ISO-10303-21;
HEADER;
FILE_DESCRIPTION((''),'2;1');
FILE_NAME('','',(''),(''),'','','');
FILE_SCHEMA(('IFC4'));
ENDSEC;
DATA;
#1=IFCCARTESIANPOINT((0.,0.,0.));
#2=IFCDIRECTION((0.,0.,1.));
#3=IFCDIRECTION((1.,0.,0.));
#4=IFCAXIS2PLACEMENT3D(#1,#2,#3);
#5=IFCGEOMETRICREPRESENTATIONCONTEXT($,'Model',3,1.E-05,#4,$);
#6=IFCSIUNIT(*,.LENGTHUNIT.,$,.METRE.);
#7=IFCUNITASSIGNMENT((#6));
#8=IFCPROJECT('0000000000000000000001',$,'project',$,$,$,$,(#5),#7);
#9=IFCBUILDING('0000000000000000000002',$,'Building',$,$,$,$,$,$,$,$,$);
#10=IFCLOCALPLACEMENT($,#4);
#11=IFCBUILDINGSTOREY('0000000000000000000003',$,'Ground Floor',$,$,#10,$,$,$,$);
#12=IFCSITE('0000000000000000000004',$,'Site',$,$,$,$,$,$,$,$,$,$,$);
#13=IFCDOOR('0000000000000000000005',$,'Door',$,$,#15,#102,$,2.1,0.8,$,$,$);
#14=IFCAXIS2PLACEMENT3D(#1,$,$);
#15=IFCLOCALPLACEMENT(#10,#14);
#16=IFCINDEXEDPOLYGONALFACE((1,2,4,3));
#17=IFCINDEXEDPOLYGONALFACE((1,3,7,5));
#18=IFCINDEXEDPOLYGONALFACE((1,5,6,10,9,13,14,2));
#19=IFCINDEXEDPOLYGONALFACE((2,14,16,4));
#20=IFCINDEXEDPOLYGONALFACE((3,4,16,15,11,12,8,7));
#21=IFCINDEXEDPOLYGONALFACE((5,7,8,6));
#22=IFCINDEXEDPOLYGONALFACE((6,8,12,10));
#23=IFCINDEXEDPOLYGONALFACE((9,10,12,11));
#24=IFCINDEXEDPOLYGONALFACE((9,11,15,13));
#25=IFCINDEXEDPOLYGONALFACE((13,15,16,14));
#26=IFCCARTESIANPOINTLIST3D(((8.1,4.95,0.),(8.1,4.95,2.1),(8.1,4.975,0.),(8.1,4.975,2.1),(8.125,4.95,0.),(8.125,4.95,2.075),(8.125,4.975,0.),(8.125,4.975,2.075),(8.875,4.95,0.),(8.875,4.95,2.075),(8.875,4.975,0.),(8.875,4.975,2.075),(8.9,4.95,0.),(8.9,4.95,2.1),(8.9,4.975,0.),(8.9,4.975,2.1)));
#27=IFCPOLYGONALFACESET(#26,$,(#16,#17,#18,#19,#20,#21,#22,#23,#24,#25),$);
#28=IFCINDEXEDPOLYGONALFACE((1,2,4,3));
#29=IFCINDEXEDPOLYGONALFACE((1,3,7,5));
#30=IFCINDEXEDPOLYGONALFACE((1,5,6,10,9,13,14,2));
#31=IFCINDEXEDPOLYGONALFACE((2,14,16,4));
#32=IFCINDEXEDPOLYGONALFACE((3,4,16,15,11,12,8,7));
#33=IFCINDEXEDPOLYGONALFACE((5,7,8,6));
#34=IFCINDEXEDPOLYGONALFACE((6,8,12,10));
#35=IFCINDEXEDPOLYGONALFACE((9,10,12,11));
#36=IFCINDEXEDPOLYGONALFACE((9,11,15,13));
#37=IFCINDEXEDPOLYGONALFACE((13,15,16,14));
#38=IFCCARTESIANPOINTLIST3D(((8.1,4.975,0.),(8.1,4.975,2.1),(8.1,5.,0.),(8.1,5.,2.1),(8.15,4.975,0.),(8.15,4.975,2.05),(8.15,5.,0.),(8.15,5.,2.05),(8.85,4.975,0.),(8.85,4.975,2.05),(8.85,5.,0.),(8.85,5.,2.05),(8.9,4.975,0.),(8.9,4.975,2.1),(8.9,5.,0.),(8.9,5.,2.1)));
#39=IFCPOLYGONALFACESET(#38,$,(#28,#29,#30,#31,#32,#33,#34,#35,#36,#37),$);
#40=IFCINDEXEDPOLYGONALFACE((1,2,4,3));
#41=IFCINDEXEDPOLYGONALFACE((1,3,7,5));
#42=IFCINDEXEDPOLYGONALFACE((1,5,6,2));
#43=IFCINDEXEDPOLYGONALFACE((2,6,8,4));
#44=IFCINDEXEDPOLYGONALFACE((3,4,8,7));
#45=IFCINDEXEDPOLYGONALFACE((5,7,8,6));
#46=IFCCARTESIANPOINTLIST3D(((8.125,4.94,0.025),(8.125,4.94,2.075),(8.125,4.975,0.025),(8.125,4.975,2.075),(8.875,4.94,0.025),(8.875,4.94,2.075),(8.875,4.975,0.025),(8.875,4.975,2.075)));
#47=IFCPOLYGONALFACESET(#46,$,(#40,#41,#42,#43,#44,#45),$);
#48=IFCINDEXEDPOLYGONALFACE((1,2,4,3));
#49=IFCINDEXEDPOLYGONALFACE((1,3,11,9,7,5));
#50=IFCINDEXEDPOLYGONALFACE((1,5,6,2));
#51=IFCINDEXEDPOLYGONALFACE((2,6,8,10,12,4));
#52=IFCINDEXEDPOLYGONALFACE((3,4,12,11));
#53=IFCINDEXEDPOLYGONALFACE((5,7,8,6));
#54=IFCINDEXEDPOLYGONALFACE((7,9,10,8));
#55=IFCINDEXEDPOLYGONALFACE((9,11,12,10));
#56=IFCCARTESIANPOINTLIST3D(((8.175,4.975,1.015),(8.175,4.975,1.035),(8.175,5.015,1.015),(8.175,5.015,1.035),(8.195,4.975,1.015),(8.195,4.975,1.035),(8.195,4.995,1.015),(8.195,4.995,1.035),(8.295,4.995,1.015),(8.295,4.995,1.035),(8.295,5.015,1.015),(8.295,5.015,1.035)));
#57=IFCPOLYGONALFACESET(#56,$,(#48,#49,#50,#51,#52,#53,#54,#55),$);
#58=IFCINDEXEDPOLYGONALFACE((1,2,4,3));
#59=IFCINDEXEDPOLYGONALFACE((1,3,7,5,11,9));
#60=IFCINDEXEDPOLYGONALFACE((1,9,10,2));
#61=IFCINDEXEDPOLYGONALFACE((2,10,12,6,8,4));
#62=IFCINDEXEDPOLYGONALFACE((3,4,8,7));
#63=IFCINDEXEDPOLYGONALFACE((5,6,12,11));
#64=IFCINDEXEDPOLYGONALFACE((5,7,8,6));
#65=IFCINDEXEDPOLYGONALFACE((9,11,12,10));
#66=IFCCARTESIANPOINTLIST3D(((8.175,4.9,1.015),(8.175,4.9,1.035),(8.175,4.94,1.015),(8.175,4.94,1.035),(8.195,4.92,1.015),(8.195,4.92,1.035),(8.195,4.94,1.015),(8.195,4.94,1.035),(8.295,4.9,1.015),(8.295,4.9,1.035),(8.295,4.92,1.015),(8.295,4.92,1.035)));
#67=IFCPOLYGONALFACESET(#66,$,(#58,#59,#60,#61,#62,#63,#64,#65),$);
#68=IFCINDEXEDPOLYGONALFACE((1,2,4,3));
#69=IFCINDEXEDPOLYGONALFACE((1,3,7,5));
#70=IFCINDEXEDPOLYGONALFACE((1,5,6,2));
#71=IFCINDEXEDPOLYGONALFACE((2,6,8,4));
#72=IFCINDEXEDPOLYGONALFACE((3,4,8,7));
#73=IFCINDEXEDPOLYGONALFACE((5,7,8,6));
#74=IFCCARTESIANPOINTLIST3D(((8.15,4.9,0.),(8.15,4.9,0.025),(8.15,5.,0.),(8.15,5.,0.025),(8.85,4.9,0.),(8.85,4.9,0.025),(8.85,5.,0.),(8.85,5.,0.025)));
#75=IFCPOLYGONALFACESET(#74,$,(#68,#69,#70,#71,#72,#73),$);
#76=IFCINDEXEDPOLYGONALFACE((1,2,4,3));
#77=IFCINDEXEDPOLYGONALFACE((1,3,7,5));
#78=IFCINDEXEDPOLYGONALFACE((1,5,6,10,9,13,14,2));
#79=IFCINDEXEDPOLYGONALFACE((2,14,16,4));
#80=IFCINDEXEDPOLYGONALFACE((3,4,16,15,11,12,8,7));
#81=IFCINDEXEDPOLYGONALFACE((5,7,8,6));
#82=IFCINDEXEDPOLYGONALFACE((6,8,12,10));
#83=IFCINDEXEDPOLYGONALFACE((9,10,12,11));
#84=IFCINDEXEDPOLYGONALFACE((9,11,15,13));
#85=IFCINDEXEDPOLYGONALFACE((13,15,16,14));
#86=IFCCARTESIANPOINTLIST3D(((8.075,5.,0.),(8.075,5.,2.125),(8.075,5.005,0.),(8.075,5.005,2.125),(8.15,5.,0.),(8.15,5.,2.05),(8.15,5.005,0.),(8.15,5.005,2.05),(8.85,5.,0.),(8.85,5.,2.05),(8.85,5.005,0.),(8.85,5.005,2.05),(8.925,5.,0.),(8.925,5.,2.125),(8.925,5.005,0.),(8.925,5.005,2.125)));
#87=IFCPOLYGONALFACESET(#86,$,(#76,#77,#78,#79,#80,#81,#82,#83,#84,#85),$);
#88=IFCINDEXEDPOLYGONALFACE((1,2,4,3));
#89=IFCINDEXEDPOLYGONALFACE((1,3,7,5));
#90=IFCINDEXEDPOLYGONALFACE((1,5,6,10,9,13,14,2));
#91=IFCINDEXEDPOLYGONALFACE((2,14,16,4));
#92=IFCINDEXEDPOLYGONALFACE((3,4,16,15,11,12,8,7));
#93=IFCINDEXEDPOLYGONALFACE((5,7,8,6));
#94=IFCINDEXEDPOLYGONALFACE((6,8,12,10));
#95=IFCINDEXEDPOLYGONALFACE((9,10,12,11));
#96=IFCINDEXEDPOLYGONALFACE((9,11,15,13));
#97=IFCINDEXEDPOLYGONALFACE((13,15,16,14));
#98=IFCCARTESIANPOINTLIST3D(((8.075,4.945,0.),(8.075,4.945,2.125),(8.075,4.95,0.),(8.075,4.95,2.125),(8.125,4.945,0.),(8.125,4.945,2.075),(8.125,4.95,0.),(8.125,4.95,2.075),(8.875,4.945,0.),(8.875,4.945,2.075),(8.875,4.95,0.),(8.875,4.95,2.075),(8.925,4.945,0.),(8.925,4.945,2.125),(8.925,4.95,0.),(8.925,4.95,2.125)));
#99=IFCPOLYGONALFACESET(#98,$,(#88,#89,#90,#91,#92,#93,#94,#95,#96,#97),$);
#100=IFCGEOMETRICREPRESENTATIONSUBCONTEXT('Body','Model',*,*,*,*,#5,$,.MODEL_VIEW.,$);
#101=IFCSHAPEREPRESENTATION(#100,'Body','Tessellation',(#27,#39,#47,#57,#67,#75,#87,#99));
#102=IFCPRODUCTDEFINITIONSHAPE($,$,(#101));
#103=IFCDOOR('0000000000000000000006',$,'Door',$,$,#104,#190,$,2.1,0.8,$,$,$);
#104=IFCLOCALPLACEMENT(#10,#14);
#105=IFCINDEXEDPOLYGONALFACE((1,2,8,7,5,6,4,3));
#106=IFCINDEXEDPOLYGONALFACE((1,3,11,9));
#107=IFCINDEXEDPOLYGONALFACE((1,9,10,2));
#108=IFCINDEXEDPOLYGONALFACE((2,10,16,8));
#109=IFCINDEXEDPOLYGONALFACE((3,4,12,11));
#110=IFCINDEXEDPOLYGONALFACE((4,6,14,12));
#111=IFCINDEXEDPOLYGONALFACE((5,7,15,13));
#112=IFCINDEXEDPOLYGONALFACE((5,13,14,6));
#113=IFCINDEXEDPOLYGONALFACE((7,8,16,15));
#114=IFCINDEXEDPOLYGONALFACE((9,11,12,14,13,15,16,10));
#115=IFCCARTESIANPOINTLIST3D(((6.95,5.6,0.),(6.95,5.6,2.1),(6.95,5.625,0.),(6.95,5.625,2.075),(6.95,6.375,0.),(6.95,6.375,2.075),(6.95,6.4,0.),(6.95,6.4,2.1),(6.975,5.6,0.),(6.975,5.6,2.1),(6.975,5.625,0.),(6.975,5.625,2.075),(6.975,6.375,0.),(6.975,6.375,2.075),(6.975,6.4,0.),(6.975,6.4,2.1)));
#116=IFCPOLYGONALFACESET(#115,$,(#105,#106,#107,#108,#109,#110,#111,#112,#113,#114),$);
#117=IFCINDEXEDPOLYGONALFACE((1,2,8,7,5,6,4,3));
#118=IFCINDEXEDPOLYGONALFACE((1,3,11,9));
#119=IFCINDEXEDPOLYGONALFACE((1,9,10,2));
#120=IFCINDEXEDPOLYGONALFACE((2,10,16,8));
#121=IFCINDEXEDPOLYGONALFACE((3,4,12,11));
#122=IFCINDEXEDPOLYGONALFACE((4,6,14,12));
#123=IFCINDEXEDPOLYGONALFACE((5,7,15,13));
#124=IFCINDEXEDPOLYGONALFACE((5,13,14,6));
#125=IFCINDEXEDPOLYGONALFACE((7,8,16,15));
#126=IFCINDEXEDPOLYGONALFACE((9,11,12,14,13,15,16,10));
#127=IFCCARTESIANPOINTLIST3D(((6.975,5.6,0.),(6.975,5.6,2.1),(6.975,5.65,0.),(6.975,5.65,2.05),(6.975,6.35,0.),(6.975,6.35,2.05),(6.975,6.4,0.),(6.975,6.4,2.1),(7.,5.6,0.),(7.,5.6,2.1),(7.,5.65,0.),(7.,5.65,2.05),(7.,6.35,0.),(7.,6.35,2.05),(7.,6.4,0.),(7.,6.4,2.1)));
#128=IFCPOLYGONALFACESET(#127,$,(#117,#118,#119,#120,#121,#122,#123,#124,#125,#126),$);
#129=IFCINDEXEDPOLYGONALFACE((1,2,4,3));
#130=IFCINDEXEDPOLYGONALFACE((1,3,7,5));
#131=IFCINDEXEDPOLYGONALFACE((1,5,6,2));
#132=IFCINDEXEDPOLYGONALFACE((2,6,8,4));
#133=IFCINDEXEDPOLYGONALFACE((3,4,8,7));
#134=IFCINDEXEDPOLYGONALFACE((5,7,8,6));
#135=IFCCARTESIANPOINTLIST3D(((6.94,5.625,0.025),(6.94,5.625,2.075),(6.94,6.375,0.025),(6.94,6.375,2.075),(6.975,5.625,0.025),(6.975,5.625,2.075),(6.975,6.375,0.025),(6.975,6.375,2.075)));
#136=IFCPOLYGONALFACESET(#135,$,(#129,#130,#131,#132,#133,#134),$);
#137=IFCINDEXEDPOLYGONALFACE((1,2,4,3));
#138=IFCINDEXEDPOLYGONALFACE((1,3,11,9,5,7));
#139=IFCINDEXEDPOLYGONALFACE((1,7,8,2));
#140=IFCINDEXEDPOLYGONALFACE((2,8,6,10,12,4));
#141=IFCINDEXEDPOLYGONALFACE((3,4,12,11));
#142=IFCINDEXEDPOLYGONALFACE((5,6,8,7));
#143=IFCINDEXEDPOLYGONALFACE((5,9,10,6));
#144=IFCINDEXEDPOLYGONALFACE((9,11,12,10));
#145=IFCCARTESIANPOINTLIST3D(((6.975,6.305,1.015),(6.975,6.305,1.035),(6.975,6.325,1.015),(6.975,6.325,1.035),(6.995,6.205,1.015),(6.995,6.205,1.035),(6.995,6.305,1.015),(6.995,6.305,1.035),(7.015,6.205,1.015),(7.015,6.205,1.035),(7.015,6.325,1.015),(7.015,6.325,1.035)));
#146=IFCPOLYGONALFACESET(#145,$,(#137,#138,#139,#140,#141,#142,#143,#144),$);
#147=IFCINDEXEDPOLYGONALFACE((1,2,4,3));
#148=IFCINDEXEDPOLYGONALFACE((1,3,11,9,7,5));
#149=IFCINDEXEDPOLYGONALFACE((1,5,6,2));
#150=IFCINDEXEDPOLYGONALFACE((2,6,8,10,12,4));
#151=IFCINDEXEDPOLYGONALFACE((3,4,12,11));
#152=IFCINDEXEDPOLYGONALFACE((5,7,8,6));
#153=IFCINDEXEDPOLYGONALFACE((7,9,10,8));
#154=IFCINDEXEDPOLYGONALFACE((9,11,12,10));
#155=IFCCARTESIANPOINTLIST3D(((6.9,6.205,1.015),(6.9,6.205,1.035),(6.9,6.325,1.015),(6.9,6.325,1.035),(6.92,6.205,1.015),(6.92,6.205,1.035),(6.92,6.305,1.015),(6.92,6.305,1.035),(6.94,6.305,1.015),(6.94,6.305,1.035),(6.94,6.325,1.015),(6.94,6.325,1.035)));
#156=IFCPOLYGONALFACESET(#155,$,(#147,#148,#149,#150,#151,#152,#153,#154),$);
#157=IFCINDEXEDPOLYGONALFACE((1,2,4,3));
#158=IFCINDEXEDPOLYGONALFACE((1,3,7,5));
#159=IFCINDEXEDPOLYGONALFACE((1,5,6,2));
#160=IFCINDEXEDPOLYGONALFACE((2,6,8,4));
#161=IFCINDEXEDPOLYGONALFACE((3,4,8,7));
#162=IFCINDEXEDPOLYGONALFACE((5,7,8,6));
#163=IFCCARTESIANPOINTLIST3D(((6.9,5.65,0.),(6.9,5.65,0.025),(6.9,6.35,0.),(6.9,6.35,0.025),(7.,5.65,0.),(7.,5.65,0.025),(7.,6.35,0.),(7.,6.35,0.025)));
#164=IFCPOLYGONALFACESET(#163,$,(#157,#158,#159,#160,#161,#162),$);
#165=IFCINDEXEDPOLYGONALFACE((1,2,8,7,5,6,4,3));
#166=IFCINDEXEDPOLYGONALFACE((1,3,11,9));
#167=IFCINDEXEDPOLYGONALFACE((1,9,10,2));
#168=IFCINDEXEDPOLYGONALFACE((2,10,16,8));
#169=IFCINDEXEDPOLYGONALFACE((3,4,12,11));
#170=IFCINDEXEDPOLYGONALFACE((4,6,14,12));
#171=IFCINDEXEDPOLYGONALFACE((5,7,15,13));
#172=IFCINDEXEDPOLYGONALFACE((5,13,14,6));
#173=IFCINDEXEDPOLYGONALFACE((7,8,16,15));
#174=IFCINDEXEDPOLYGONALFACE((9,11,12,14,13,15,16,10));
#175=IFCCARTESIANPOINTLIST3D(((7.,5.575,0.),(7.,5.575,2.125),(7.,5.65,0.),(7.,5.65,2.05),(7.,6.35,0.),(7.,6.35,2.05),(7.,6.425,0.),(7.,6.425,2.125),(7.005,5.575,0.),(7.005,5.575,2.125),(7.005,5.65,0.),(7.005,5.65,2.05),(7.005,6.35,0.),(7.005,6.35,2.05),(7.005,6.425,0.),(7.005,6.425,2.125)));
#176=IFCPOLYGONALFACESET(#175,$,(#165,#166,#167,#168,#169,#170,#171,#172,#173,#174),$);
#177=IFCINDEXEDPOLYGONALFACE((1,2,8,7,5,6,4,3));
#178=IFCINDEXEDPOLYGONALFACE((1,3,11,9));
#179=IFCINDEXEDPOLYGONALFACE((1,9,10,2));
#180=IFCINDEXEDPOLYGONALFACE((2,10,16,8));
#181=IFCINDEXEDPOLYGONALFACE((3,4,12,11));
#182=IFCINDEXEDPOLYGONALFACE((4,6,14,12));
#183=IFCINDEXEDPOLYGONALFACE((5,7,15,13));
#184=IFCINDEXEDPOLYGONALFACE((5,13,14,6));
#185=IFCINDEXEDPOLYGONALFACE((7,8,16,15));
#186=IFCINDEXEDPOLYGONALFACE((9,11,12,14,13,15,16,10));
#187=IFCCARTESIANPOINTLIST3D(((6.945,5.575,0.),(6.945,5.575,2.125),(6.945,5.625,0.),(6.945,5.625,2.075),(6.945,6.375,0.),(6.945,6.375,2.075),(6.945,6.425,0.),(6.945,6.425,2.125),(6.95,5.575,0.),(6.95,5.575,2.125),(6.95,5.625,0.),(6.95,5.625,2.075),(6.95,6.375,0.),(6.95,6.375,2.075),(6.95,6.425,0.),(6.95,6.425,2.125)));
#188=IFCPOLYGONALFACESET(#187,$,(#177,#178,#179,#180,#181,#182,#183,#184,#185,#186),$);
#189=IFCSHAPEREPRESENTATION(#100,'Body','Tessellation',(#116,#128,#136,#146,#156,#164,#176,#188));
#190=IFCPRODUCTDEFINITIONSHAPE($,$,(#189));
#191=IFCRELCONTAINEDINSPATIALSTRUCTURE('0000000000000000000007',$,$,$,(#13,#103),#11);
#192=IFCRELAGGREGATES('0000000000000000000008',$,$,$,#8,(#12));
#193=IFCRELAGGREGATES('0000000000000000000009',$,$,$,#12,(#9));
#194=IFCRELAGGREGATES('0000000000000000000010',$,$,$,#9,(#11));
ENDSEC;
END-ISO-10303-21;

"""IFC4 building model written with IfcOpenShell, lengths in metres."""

from ifc_helpers import new_model, si_unit, frame, origin_with_axes, place, context, subcontext, project, spatial, line, indexed_curve, outline, extrude, element, save


model = new_model("IFC4")

# Units and contexts
model_context = context("Model", 3, precision=1e-05, world=origin_with_axes())
body_context = subcontext(model_context, "Body", "Model", "MODEL_VIEW")
ifc_project = project(units=[si_unit("LENGTHUNIT", "METRE")], contexts=[model_context])

# Site, building, storey
site = spatial("IfcSite", under=ifc_project, Name="Site")
building = spatial("IfcBuilding", under=site, Name="Building")
storey_placement = place(None, origin_with_axes())
storey = spatial("IfcBuildingStorey", under=building, at=storey_placement, Name="Ground Floor")

# Doors
door_1_placement = place(storey_placement, frame((8.9, 5.0, 0.0), z_axis=(0.0, 0.0, 1.0), x_axis=(-1.0, 0.0, 0.0)))
element("IfcDoor", 1, at=door_1_placement, inside=storey, Name="Door", OverallHeight=2.1, OverallWidth=0.8, context=body_context, shape_type="SweptSolid", body=[
    extrude(outline(indexed_curve([(0.0, 0.0), (0.0, 2.1), (0.8, 2.1), (0.8, 0.0), (0.775, 0.0), (0.775, 2.075), (0.025, 2.075), (0.025, 0.0)], segments=[line(1, 2, 3, 4, 5, 6, 7, 8, 1)])), frame((0.0, 0.025, 0.0), z_axis=(0.0, -1.0, 0.0), x_axis=(1.0, 0.0, 0.0)), (0.0, 0.0, -1.0), 0.025),
    extrude(outline(indexed_curve([(0.0, 0.0), (0.0, 2.1), (0.8, 2.1), (0.8, 0.0), (0.75, 0.0), (0.75, 2.05), (0.05, 2.05), (0.05, 0.0)], segments=[line(1, 2, 3, 4, 5, 6, 7, 8, 1)])), frame((0.0, 0.0, 0.0), z_axis=(0.0, -1.0, 0.0), x_axis=(1.0, 0.0, 0.0)), (0.0, 0.0, -1.0), 0.025),
    extrude(outline(indexed_curve([(0.0, 0.0), (0.75, 0.0), (0.75, 0.035), (0.0, 0.035)], segments=[line(1, 2, 3, 4, 1)])), frame((0.025, 0.025, 0.025), z_axis=(0.0, 0.0, 1.0), x_axis=(1.0, 0.0, 0.0)), (0.0, 0.0, 1.0), 2.05),
    extrude(outline(indexed_curve([(0.0, 0.0), (0.0, -0.04), (-0.12, -0.04), (-0.12, -0.02), (-0.02, -0.02), (-0.02, 0.0)], segments=[line(1, 2, 3, 4, 5, 6, 1)])), frame((0.725, 0.025, 1.015), z_axis=(0.0, 0.0, 1.0), x_axis=(1.0, 0.0, 0.0)), (0.0, 0.0, 1.0), 0.02),
    extrude(outline(indexed_curve([(0.0, 0.0), (0.0, 0.04), (-0.12, 0.04), (-0.12, 0.02), (-0.02, 0.02), (-0.02, 0.0)], segments=[line(1, 2, 3, 4, 5, 6, 1)])), frame((0.725, 0.06, 1.015), z_axis=(0.0, 0.0, 1.0), x_axis=(1.0, 0.0, 0.0)), (0.0, 0.0, 1.0), 0.02),
    extrude(outline(indexed_curve([(0.0, 0.0), (0.7, 0.0), (0.7, 0.1), (0.0, 0.1)], segments=[line(1, 2, 3, 4, 1)])), frame((0.05, 0.0, 0.0), z_axis=(0.0, 0.0, 1.0), x_axis=(1.0, 0.0, 0.0)), (0.0, 0.0, 1.0), 0.025),
    extrude(outline(indexed_curve([(0.0, 0.0), (0.0, 2.125), (0.85, 2.125), (0.85, 0.0), (0.775, 0.0), (0.775, 2.05), (0.075, 2.05), (0.075, 0.0)], segments=[line(1, 2, 3, 4, 5, 6, 7, 8, 1)])), frame((-0.025, -0.005, 0.0), z_axis=(0.0, -1.0, 0.0), x_axis=(1.0, 0.0, 0.0)), (0.0, 0.0, -1.0), 0.005),
    extrude(outline(indexed_curve([(0.0, 0.0), (0.0, 2.125), (0.85, 2.125), (0.85, 0.0), (0.8, 0.0), (0.8, 2.075), (0.05, 2.075), (0.05, 0.0)], segments=[line(1, 2, 3, 4, 5, 6, 7, 8, 1)])), frame((-0.025, 0.05, 0.0), z_axis=(0.0, -1.0, 0.0), x_axis=(1.0, 0.0, 0.0)), (0.0, 0.0, -1.0), 0.005),
])
door_2_placement = place(storey_placement, frame((7.0, 5.6, 0.0), z_axis=(0.0, 0.0, 1.0), x_axis=(0.0, 1.0, 0.0)))
element("IfcDoor", 2, at=door_2_placement, inside=storey, Name="Door", OverallHeight=2.1, OverallWidth=0.8, context=body_context, shape_type="SweptSolid", body=[
    extrude(outline(indexed_curve([(0.0, 0.0), (0.0, 2.1), (0.8, 2.1), (0.8, 0.0), (0.775, 0.0), (0.775, 2.075), (0.025, 2.075), (0.025, 0.0)], segments=[line(1, 2, 3, 4, 5, 6, 7, 8, 1)])), frame((0.0, 0.025, 0.0), z_axis=(0.0, -1.0, 0.0), x_axis=(1.0, 0.0, 0.0)), (0.0, 0.0, -1.0), 0.025),
    extrude(outline(indexed_curve([(0.0, 0.0), (0.0, 2.1), (0.8, 2.1), (0.8, 0.0), (0.75, 0.0), (0.75, 2.05), (0.05, 2.05), (0.05, 0.0)], segments=[line(1, 2, 3, 4, 5, 6, 7, 8, 1)])), frame((0.0, 0.0, 0.0), z_axis=(0.0, -1.0, 0.0), x_axis=(1.0, 0.0, 0.0)), (0.0, 0.0, -1.0), 0.025),
    extrude(outline(indexed_curve([(0.0, 0.0), (0.75, 0.0), (0.75, 0.035), (0.0, 0.035)], segments=[line(1, 2, 3, 4, 1)])), frame((0.025, 0.025, 0.025), z_axis=(0.0, 0.0, 1.0), x_axis=(1.0, 0.0, 0.0)), (0.0, 0.0, 1.0), 2.05),
    extrude(outline(indexed_curve([(0.0, 0.0), (0.0, -0.04), (-0.12, -0.04), (-0.12, -0.02), (-0.02, -0.02), (-0.02, 0.0)], segments=[line(1, 2, 3, 4, 5, 6, 1)])), frame((0.725, 0.025, 1.015), z_axis=(0.0, 0.0, 1.0), x_axis=(1.0, 0.0, 0.0)), (0.0, 0.0, 1.0), 0.02),
    extrude(outline(indexed_curve([(0.0, 0.0), (0.0, 0.04), (-0.12, 0.04), (-0.12, 0.02), (-0.02, 0.02), (-0.02, 0.0)], segments=[line(1, 2, 3, 4, 5, 6, 1)])), frame((0.725, 0.06, 1.015), z_axis=(0.0, 0.0, 1.0), x_axis=(1.0, 0.0, 0.0)), (0.0, 0.0, 1.0), 0.02),
    extrude(outline(indexed_curve([(0.0, 0.0), (0.7, 0.0), (0.7, 0.1), (0.0, 0.1)], segments=[line(1, 2, 3, 4, 1)])), frame((0.05, 0.0, 0.0), z_axis=(0.0, 0.0, 1.0), x_axis=(1.0, 0.0, 0.0)), (0.0, 0.0, 1.0), 0.025),
    extrude(outline(indexed_curve([(0.0, 0.0), (0.0, 2.125), (0.85, 2.125), (0.85, 0.0), (0.775, 0.0), (0.775, 2.05), (0.075, 2.05), (0.075, 0.0)], segments=[line(1, 2, 3, 4, 5, 6, 7, 8, 1)])), frame((-0.025, -0.005, 0.0), z_axis=(0.0, -1.0, 0.0), x_axis=(1.0, 0.0, 0.0)), (0.0, 0.0, -1.0), 0.005),
    extrude(outline(indexed_curve([(0.0, 0.0), (0.0, 2.125), (0.85, 2.125), (0.85, 0.0), (0.8, 0.0), (0.8, 2.075), (0.05, 2.075), (0.05, 0.0)], segments=[line(1, 2, 3, 4, 5, 6, 7, 8, 1)])), frame((-0.025, 0.05, 0.0), z_axis=(0.0, -1.0, 0.0), x_axis=(1.0, 0.0, 0.0)), (0.0, 0.0, -1.0), 0.005),
])

save(model, "model.ifc")
